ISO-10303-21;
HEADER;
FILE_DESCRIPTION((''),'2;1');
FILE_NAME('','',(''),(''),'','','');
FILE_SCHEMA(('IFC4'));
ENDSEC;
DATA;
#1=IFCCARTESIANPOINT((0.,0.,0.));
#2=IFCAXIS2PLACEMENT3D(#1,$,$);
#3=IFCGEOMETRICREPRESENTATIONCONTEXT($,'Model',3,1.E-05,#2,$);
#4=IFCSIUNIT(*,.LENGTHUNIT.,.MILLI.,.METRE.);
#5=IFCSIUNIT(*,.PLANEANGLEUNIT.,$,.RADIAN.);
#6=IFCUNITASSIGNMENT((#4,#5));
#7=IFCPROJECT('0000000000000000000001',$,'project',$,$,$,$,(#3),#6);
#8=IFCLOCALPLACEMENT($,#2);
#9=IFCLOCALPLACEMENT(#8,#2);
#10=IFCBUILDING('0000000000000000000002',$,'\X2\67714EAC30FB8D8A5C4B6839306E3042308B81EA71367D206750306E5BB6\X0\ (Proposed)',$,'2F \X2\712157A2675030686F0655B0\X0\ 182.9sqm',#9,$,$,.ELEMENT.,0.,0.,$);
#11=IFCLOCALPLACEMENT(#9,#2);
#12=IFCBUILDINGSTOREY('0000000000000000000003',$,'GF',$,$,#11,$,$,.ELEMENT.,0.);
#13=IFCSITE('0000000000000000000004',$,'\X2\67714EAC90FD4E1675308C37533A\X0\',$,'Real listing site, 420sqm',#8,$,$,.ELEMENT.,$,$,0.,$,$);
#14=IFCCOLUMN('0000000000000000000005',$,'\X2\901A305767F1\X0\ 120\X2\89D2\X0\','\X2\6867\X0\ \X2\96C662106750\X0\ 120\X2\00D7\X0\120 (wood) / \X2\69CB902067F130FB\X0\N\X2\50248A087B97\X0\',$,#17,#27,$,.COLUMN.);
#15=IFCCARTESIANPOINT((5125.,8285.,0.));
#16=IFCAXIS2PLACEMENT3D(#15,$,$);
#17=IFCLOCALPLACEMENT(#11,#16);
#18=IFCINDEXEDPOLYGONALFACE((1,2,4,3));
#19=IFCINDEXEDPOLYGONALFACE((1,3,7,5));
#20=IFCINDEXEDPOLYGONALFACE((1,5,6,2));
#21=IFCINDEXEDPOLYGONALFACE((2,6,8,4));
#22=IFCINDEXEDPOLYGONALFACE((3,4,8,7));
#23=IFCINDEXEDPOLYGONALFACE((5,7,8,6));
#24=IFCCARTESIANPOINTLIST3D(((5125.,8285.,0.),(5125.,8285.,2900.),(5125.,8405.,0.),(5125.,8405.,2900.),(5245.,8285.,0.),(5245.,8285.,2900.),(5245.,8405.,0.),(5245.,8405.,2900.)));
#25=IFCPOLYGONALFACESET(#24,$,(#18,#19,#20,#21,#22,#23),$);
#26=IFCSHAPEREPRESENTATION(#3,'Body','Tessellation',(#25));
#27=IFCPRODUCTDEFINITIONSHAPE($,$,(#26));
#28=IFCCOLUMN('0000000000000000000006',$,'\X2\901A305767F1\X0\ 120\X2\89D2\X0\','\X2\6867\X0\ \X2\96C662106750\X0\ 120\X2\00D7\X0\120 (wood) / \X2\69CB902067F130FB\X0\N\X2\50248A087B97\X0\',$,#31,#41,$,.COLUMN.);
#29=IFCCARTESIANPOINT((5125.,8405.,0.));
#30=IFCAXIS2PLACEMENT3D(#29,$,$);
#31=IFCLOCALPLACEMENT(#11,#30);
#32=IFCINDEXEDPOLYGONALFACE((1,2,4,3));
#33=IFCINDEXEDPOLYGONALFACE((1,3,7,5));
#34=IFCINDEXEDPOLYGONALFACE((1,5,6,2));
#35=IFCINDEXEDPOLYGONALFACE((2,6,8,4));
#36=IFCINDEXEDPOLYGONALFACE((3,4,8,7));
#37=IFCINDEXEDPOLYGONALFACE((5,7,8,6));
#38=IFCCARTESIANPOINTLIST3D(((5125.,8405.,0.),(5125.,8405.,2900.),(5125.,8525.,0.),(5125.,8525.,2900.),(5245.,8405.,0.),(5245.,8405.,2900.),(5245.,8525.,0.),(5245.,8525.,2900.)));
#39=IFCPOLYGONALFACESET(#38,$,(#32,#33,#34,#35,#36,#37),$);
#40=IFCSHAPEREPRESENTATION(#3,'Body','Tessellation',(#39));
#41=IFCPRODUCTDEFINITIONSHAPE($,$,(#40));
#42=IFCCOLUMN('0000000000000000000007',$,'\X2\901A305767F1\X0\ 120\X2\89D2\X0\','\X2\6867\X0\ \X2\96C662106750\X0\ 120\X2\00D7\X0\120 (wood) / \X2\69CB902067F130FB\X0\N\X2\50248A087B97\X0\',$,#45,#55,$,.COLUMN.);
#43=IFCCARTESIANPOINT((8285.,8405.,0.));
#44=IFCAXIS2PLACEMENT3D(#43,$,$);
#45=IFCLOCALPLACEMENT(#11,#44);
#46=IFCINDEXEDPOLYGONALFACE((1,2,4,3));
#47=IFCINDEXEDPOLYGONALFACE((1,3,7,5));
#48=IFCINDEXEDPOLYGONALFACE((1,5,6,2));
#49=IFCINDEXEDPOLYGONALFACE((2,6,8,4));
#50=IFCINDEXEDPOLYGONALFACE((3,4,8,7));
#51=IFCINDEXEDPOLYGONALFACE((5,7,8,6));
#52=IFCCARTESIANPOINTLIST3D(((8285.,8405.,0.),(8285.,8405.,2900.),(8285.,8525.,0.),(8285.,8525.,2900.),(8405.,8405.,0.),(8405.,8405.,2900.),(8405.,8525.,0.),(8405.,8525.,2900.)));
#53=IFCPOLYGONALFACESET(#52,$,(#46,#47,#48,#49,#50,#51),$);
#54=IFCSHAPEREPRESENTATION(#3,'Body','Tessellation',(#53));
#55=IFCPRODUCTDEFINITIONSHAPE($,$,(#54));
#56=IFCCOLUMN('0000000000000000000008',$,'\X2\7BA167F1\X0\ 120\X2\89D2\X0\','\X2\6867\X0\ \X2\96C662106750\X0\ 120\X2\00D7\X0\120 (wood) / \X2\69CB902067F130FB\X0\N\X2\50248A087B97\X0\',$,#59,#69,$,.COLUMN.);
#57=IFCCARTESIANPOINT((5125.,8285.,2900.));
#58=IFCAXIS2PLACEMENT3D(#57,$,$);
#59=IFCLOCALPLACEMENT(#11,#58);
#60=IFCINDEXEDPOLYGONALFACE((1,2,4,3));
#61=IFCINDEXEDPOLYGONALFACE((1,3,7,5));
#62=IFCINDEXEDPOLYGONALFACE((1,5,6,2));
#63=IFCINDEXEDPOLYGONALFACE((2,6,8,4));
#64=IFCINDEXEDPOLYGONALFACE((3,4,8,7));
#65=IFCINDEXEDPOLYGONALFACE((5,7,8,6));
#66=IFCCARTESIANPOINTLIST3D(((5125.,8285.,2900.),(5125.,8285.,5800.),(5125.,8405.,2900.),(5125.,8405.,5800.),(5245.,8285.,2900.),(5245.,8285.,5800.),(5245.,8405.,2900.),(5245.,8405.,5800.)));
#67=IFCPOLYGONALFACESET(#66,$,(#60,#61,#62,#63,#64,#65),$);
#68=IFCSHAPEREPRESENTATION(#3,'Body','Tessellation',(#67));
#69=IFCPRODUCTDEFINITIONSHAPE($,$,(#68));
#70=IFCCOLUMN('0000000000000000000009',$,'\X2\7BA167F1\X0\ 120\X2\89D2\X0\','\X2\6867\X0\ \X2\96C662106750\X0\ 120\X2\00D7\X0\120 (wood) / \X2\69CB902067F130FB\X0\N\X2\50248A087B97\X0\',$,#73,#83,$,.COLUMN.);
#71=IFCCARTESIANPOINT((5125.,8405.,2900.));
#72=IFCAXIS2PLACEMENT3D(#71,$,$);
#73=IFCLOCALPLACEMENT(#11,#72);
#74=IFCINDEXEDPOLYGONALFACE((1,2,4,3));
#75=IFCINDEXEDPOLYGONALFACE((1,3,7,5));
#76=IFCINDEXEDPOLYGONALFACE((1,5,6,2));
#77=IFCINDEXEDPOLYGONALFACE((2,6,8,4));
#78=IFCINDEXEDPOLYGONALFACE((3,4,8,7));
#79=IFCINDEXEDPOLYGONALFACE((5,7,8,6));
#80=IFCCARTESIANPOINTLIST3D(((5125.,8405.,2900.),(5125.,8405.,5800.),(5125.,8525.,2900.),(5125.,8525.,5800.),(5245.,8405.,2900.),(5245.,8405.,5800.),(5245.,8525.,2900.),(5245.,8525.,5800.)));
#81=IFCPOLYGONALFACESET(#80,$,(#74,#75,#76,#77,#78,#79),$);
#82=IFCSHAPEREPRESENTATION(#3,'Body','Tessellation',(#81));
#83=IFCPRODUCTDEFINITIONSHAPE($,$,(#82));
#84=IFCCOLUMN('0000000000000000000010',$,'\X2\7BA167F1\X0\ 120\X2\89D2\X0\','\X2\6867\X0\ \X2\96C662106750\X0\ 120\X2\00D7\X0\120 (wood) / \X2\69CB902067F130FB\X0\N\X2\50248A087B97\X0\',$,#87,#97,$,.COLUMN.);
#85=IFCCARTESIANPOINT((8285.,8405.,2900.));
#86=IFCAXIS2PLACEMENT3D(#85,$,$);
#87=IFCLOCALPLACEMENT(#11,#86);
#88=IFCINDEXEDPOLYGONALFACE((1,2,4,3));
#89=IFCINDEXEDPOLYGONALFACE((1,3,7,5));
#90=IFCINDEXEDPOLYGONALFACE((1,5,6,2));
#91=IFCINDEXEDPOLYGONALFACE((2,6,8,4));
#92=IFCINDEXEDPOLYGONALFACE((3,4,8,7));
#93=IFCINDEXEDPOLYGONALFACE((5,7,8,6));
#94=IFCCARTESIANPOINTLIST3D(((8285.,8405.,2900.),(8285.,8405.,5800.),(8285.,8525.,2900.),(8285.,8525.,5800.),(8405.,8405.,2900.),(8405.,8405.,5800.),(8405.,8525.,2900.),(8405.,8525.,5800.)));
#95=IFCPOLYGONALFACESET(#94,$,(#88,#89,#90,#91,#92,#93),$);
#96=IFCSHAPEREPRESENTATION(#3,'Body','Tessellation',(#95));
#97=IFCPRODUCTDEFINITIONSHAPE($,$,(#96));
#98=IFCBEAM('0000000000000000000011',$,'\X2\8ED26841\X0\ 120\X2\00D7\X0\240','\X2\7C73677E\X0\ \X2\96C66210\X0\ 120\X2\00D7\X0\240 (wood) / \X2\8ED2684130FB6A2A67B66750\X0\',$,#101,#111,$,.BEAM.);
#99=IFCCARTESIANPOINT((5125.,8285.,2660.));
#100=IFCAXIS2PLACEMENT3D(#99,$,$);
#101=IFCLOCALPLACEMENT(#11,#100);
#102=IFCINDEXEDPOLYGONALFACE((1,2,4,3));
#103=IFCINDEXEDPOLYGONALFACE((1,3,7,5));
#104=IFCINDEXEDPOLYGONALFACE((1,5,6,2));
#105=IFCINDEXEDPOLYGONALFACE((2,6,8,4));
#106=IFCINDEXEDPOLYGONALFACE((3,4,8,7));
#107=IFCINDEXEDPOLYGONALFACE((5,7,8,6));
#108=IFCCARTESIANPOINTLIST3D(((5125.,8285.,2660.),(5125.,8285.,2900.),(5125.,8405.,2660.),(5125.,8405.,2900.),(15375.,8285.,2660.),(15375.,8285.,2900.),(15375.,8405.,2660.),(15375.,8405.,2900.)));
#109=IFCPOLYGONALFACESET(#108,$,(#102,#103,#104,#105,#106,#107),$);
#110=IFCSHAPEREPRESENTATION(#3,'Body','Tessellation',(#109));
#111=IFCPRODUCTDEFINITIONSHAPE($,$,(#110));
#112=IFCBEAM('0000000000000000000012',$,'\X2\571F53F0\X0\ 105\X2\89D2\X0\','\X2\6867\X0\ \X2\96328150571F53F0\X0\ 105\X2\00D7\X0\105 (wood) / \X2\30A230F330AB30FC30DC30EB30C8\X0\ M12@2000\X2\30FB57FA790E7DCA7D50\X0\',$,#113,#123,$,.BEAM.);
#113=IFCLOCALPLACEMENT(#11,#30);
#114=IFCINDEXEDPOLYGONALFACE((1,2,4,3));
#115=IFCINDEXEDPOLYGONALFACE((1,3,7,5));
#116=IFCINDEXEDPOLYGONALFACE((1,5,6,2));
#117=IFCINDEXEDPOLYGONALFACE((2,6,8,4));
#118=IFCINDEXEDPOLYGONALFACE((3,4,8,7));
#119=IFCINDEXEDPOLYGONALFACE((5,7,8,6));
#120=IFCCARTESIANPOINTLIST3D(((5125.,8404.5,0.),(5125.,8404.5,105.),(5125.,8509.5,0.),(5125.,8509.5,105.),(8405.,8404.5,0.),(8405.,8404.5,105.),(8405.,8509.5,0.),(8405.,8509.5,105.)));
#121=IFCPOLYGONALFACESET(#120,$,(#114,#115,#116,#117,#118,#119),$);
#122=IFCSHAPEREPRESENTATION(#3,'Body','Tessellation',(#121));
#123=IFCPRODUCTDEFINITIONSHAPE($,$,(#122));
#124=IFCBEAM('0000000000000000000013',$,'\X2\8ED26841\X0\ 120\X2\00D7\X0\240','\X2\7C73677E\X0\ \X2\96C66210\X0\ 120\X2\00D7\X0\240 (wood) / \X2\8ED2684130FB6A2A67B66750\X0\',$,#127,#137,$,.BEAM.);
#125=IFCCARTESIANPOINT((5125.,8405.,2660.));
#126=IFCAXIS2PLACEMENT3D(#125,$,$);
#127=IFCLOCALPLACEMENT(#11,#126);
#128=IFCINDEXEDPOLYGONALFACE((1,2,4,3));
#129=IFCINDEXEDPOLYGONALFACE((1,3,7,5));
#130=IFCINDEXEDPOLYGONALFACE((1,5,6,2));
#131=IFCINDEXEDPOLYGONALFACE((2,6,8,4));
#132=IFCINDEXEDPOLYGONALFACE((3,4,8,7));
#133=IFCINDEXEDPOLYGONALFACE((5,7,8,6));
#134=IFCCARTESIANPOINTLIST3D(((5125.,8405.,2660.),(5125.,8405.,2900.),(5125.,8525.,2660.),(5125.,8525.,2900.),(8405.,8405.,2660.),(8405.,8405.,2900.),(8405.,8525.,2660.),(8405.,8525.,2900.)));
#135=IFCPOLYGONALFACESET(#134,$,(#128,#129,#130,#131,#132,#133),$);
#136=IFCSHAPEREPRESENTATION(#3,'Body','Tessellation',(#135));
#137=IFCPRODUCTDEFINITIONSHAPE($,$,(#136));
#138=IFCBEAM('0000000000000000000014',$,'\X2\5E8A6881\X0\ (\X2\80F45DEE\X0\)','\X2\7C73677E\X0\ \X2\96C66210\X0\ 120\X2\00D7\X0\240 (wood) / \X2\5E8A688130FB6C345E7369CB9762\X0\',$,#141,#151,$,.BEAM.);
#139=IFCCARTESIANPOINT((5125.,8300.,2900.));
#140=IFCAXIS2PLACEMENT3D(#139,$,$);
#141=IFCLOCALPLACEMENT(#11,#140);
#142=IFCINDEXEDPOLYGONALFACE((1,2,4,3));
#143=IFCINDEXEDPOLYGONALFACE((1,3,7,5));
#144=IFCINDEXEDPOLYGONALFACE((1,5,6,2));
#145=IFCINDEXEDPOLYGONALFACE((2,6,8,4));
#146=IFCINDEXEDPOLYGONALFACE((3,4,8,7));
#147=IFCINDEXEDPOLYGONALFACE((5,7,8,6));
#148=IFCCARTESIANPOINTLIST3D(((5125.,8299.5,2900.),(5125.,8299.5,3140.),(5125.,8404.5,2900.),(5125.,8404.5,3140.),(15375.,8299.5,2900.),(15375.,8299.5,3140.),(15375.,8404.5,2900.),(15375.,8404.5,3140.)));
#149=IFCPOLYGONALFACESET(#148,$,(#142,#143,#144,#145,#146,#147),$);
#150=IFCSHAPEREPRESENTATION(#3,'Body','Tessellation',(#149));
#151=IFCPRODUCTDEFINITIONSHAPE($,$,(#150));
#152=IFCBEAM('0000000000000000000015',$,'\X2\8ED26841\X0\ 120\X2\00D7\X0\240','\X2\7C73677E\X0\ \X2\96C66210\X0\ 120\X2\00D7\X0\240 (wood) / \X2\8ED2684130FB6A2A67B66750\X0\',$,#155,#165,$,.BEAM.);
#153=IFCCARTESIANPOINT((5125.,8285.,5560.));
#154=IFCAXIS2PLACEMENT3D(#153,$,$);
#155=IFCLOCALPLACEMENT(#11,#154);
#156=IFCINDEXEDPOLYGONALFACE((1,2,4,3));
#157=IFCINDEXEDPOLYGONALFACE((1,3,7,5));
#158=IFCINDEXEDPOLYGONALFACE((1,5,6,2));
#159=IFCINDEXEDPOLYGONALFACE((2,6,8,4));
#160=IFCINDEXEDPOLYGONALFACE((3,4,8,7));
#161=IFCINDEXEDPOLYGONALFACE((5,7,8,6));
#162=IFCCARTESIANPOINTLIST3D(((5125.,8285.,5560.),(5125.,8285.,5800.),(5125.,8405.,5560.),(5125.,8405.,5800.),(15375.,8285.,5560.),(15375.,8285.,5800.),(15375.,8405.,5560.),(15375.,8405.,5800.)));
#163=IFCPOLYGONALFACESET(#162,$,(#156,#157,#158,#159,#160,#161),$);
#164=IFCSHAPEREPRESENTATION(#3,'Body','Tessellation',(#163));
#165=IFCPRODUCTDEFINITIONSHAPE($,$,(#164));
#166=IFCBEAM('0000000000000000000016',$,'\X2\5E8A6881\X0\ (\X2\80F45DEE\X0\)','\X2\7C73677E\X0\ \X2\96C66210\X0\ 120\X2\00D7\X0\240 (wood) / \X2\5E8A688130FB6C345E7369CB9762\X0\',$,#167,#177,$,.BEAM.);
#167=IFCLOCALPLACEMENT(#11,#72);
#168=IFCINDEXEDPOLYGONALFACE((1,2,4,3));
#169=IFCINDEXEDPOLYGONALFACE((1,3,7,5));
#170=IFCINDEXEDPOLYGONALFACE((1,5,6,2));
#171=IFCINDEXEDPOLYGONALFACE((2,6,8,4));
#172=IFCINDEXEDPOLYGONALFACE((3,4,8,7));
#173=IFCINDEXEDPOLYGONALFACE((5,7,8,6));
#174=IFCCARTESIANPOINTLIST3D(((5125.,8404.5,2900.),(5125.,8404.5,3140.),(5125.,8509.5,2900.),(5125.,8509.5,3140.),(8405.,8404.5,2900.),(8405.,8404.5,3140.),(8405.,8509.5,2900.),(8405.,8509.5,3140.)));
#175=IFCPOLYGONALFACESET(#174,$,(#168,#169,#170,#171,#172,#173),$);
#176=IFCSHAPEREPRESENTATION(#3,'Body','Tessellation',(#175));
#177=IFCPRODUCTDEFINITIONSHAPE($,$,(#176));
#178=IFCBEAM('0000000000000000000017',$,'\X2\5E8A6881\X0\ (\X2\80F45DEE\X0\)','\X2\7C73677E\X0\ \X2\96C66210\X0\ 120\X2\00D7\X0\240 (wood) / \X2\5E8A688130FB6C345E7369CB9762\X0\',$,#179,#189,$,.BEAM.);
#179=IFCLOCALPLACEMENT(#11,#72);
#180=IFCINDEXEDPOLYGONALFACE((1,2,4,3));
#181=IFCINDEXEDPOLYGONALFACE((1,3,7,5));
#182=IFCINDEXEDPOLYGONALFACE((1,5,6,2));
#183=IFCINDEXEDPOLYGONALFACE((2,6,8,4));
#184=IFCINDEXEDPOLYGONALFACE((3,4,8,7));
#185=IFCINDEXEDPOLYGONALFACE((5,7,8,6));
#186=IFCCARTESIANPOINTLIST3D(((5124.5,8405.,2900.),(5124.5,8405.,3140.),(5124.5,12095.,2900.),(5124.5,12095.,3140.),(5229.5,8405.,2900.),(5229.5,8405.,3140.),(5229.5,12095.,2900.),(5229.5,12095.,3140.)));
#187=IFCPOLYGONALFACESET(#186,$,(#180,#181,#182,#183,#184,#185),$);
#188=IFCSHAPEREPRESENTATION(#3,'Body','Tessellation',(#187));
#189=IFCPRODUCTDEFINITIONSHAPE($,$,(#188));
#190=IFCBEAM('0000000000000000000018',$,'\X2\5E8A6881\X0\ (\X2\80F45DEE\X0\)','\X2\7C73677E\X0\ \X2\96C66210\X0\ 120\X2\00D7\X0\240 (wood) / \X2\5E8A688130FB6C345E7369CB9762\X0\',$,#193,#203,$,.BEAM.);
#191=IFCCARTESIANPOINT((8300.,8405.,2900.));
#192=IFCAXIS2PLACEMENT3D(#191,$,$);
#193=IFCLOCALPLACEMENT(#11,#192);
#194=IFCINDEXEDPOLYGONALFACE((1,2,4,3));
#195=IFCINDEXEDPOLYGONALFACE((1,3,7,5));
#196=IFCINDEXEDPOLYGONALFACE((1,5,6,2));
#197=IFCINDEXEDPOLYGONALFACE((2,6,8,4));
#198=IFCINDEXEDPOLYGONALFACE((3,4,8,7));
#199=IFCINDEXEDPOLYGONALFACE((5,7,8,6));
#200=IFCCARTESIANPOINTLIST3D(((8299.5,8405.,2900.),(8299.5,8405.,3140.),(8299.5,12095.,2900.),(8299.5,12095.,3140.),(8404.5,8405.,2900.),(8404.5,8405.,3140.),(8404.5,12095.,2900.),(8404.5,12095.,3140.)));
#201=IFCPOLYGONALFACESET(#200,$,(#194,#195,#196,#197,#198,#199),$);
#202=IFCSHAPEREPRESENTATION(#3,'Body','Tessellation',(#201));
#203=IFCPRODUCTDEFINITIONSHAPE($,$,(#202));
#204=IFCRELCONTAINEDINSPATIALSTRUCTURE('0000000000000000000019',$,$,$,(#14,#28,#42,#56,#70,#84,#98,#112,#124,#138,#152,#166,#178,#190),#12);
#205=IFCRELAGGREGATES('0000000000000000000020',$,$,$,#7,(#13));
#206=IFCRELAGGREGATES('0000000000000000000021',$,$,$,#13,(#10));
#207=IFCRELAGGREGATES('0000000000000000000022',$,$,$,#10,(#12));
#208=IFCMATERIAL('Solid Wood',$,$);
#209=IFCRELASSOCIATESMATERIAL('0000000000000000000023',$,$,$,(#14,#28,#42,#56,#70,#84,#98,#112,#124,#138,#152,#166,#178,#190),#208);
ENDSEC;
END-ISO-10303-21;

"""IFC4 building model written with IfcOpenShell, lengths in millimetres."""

from ifc_helpers import new_model, si_unit, frame, frame_2d, origin, place, context, project, spatial, rectangle, extrude, material, element, save


model = new_model("IFC4")

# Units and contexts
model_context = context("Model", 3, precision=1e-05, world=origin())
ifc_project = project(units=[si_unit("LENGTHUNIT", "METRE", prefix="MILLI"), si_unit("PLANEANGLEUNIT", "RADIAN")], contexts=[model_context])

# Site, building, storey
site_placement = place(None, origin())
site = spatial("IfcSite", under=ifc_project, at=site_placement, Name="東京都世田谷区", ObjectType="Real listing site, 420sqm", CompositionType="ELEMENT", RefElevation=0.0)
building_placement = place(site_placement, origin())
building = spatial("IfcBuilding", under=site, at=building_placement, Name="東京・越屋根のある自然素材の家 (Proposed)", ObjectType="2F 無垢材と漆喰 182.9sqm", CompositionType="ELEMENT", ElevationOfRefHeight=0.0, ElevationOfTerrain=0.0)
storey_placement = place(building_placement, origin())
storey = spatial("IfcBuildingStorey", under=building, at=storey_placement, Name="GF", CompositionType="ELEMENT", Elevation=0.0)

# Columns
ifc_material_1 = material(Name="Solid Wood")
column_1_placement = place(storey_placement, frame((5125.0, 8285.0, 0.0)))
element("IfcColumn", 1, at=column_1_placement, inside=storey, material=ifc_material_1, Name="通し柱 120角", Description="桧 集成材 120×120 (wood) / 構造柱・N値計算", PredefinedType="COLUMN", context=model_context, shape_type="SweptSolid", body=[
    extrude(rectangle(XDim=120.0, YDim=120.0, at=frame_2d((60.0, 60.0))), frame((5125.0, 8285.0, 0.0)), (0.0, 0.0, 1.0), 2900.0),
])
column_2_placement = place(storey_placement, frame((5125.0, 8405.0, 0.0)))
element("IfcColumn", 2, at=column_2_placement, inside=storey, material=ifc_material_1, Name="通し柱 120角", Description="桧 集成材 120×120 (wood) / 構造柱・N値計算", PredefinedType="COLUMN", context=model_context, shape_type="SweptSolid", body=[
    extrude(rectangle(XDim=120.0, YDim=120.0, at=frame_2d((60.0, 60.0))), frame((5125.0, 8405.0, 0.0)), (0.0, 0.0, 1.0), 2900.0),
])
column_3_placement = place(storey_placement, frame((8285.0, 8405.0, 0.0)))
element("IfcColumn", 3, at=column_3_placement, inside=storey, material=ifc_material_1, Name="通し柱 120角", Description="桧 集成材 120×120 (wood) / 構造柱・N値計算", PredefinedType="COLUMN", context=model_context, shape_type="SweptSolid", body=[
    extrude(rectangle(XDim=120.0, YDim=120.0, at=frame_2d((60.0, 60.0))), frame((8285.0, 8405.0, 0.0)), (0.0, 0.0, 1.0), 2900.0),
])
column_4_placement = place(storey_placement, frame((5125.0, 8285.0, 2900.0)))
element("IfcColumn", 4, at=column_4_placement, inside=storey, material=ifc_material_1, Name="管柱 120角", Description="桧 集成材 120×120 (wood) / 構造柱・N値計算", PredefinedType="COLUMN", context=model_context, shape_type="SweptSolid", body=[
    extrude(rectangle(XDim=120.0, YDim=120.0, at=frame_2d((60.0, 60.0))), frame((5125.0, 8285.0, 2900.0)), (0.0, 0.0, 1.0), 2900.0),
])
column_5_placement = place(storey_placement, frame((5125.0, 8405.0, 2900.0)))
element("IfcColumn", 5, at=column_5_placement, inside=storey, material=ifc_material_1, Name="管柱 120角", Description="桧 集成材 120×120 (wood) / 構造柱・N値計算", PredefinedType="COLUMN", context=model_context, shape_type="SweptSolid", body=[
    extrude(rectangle(XDim=120.0, YDim=120.0, at=frame_2d((60.0, 60.0))), frame((5125.0, 8405.0, 2900.0)), (0.0, 0.0, 1.0), 2900.0),
])
column_6_placement = place(storey_placement, frame((8285.0, 8405.0, 2900.0)))
element("IfcColumn", 6, at=column_6_placement, inside=storey, material=ifc_material_1, Name="管柱 120角", Description="桧 集成材 120×120 (wood) / 構造柱・N値計算", PredefinedType="COLUMN", context=model_context, shape_type="SweptSolid", body=[
    extrude(rectangle(XDim=120.0, YDim=120.0, at=frame_2d((60.0, 60.0))), frame((8285.0, 8405.0, 2900.0)), (0.0, 0.0, 1.0), 2900.0),
])

# Beams
beam_1_placement = place(storey_placement, frame((5125.0, 8285.0, 2660.0)))
element("IfcBeam", 7, at=beam_1_placement, inside=storey, material=ifc_material_1, Name="軒桁 120×240", Description="米松 集成 120×240 (wood) / 軒桁・横架材", PredefinedType="BEAM", context=model_context, shape_type="SweptSolid", body=[
    extrude(rectangle(XDim=10250.0, YDim=120.0, at=frame_2d((5125.0, 60.0))), frame((5125.0, 8285.0, 2660.0)), (0.0, 0.0, 1.0), 240.0),
])
beam_2_placement = place(storey_placement, frame((5125.0, 8405.0, 0.0)))
element("IfcBeam", 8, at=beam_2_placement, inside=storey, material=ifc_material_1, Name="土台 105角", Description="桧 防腐土台 105×105 (wood) / アンカーボルト M12@2000・基礎緊結", PredefinedType="BEAM", context=model_context, shape_type="SweptSolid", body=[
    extrude(rectangle(XDim=3280.0, YDim=105.0, at=frame_2d((1640.0, 52.0))), frame((5125.0, 8405.0, 0.0)), (0.0, 0.0, 1.0), 105.0),
])
beam_3_placement = place(storey_placement, frame((5125.0, 8405.0, 2660.0)))
element("IfcBeam", 9, at=beam_3_placement, inside=storey, material=ifc_material_1, Name="軒桁 120×240", Description="米松 集成 120×240 (wood) / 軒桁・横架材", PredefinedType="BEAM", context=model_context, shape_type="SweptSolid", body=[
    extrude(rectangle(XDim=3280.0, YDim=120.0, at=frame_2d((1640.0, 60.0))), frame((5125.0, 8405.0, 2660.0)), (0.0, 0.0, 1.0), 240.0),
])
beam_4_placement = place(storey_placement, frame((5125.0, 8300.0, 2900.0)))
element("IfcBeam", 10, at=beam_4_placement, inside=storey, material=ifc_material_1, Name="床梁 (胴差)", Description="米松 集成 120×240 (wood) / 床梁・水平構面", PredefinedType="BEAM", context=model_context, shape_type="SweptSolid", body=[
    extrude(rectangle(XDim=10250.0, YDim=105.0, at=frame_2d((5125.0, 52.0))), frame((5125.0, 8300.0, 2900.0)), (0.0, 0.0, 1.0), 240.0),
])
beam_5_placement = place(storey_placement, frame((5125.0, 8285.0, 5560.0)))
element("IfcBeam", 11, at=beam_5_placement, inside=storey, material=ifc_material_1, Name="軒桁 120×240", Description="米松 集成 120×240 (wood) / 軒桁・横架材", PredefinedType="BEAM", context=model_context, shape_type="SweptSolid", body=[
    extrude(rectangle(XDim=10250.0, YDim=120.0, at=frame_2d((5125.0, 60.0))), frame((5125.0, 8285.0, 5560.0)), (0.0, 0.0, 1.0), 240.0),
])
beam_6_placement = place(storey_placement, frame((5125.0, 8405.0, 2900.0)))
element("IfcBeam", 12, at=beam_6_placement, inside=storey, material=ifc_material_1, Name="床梁 (胴差)", Description="米松 集成 120×240 (wood) / 床梁・水平構面", PredefinedType="BEAM", context=model_context, shape_type="SweptSolid", body=[
    extrude(rectangle(XDim=3280.0, YDim=105.0, at=frame_2d((1640.0, 52.0))), frame((5125.0, 8405.0, 2900.0)), (0.0, 0.0, 1.0), 240.0),
])
beam_7_placement = place(storey_placement, frame((5125.0, 8405.0, 2900.0)))
element("IfcBeam", 13, at=beam_7_placement, inside=storey, material=ifc_material_1, Name="床梁 (胴差)", Description="米松 集成 120×240 (wood) / 床梁・水平構面", PredefinedType="BEAM", context=model_context, shape_type="SweptSolid", body=[
    extrude(rectangle(XDim=105.0, YDim=3690.0, at=frame_2d((52.0, 1845.0))), frame((5125.0, 8405.0, 2900.0)), (0.0, 0.0, 1.0), 240.0),
])
beam_8_placement = place(storey_placement, frame((8300.0, 8405.0, 2900.0)))
element("IfcBeam", 14, at=beam_8_placement, inside=storey, material=ifc_material_1, Name="床梁 (胴差)", Description="米松 集成 120×240 (wood) / 床梁・水平構面", PredefinedType="BEAM", context=model_context, shape_type="SweptSolid", body=[
    extrude(rectangle(XDim=105.0, YDim=3690.0, at=frame_2d((52.0, 1845.0))), frame((8300.0, 8405.0, 2900.0)), (0.0, 0.0, 1.0), 240.0),
])

save(model, "model.ifc")
